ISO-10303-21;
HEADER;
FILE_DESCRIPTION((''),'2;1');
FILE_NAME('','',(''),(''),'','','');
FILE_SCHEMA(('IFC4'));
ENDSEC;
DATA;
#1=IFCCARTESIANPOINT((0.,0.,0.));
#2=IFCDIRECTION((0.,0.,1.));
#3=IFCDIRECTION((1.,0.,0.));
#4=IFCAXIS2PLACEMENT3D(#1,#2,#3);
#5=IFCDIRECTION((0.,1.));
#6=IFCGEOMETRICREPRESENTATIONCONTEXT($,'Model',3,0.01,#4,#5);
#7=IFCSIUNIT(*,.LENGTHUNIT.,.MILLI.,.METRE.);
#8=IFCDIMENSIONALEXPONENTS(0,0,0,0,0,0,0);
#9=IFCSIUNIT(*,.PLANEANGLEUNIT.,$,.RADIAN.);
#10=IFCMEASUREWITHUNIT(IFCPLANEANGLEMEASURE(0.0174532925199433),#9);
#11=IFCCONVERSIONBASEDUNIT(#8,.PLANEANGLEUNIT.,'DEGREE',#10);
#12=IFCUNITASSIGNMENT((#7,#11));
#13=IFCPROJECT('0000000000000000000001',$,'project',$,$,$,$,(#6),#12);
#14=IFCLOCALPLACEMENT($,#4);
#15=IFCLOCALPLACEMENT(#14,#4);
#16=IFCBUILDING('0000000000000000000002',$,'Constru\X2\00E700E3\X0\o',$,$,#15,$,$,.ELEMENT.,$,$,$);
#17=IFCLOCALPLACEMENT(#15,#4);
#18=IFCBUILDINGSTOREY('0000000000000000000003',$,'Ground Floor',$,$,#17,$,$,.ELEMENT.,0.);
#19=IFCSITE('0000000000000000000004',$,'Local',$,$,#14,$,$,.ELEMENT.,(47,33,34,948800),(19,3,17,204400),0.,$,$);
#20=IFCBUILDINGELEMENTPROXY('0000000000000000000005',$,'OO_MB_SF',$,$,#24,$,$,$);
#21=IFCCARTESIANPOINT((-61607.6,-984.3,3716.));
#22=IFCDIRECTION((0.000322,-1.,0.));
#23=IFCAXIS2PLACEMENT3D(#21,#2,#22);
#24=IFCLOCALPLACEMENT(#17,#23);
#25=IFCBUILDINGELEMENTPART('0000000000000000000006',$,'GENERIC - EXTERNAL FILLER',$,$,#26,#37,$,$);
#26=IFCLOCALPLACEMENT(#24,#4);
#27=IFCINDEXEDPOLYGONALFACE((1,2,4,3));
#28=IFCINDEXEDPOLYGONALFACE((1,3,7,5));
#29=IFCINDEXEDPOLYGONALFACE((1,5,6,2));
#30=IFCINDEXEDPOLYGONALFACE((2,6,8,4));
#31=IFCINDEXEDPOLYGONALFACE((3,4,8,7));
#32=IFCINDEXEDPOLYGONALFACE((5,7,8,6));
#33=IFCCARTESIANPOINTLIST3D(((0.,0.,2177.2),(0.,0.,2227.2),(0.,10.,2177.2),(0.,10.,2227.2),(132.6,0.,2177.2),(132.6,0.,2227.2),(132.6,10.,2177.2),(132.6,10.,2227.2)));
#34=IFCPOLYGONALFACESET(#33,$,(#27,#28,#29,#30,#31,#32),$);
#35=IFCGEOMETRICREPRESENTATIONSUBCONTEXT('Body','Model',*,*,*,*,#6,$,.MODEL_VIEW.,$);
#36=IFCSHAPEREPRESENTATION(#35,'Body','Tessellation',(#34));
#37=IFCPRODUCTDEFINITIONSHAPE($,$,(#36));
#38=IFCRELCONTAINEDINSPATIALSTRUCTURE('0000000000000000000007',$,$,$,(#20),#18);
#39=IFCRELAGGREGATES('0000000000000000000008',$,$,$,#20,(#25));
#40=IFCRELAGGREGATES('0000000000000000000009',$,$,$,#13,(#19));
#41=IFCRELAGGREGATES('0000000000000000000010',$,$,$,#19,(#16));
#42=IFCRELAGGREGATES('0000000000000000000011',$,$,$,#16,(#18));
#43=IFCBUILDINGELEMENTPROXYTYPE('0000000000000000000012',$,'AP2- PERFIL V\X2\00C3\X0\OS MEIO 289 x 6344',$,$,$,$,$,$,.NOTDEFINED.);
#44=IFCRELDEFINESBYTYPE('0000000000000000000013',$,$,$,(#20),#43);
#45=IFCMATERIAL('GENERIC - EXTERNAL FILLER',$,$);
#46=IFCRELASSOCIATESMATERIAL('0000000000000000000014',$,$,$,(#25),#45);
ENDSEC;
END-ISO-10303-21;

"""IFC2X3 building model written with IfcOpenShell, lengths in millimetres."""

from ifc_helpers import new_model, entity, si_unit, converted_unit, direction, frame, origin_with_axes, place, context, subcontext, project, spatial, polyline, outline, extrude, material, type_object, element, aggregate, save


model = new_model("IFC2X3")

# Units and contexts
model_context = context("Model", 3, precision=0.01, world=origin_with_axes(), true_north=direction((0.0, 1.0)))
body_context = subcontext(model_context, "Body", "Model", "MODEL_VIEW")
ifc_project = project(units=[si_unit("LENGTHUNIT", "METRE", prefix="MILLI"), converted_unit("PLANEANGLEUNIT", "DEGREE", entity("IfcPlaneAngleMeasure", 0.0174532925199433), si_unit("PLANEANGLEUNIT", "RADIAN"), dimensions=[0, 0, 0, 0, 0, 0, 0])], contexts=[model_context])

# Site, building, storey
site_placement = place(None, origin_with_axes())
site = spatial("IfcSite", under=ifc_project, at=site_placement, Name="Local", CompositionType="ELEMENT", RefLatitude=(47, 33, 34, 948800), RefLongitude=(19, 3, 17, 204400), RefElevation=0.0)
building_placement = place(site_placement, origin_with_axes())
building = spatial("IfcBuilding", under=site, at=building_placement, Name="Construção", CompositionType="ELEMENT")
storey_placement = place(building_placement, origin_with_axes())
storey = spatial("IfcBuildingStorey", under=building, at=storey_placement, Name="Ground Floor", CompositionType="ELEMENT", Elevation=0.0)

# Building element proxy, building element part
building_element_proxy_type = type_object("IfcBuildingElementProxyType", Name="AP2- PERFIL VÃOS MEIO 289 x 6344", PredefinedType="NOTDEFINED")
ifc_material_1 = material(Name="GENERIC - EXTERNAL FILLER")
proxy_1_placement = place(storey_placement, frame((-61607.6, -984.3, 3716.0), z_axis=(0.0, 0.0, 1.0), x_axis=(0.000322, -1.0, 0.0)))
proxy_1 = element("IfcBuildingElementProxy", 1, at=proxy_1_placement, inside=storey, type_object=building_element_proxy_type, Name="OO_MB_SF")
building_element_part_1_placement = place(proxy_1_placement, origin_with_axes())
building_element_part_1 = element("IfcBuildingElementPart", 2, at=building_element_part_1_placement, material=ifc_material_1, Name="GENERIC - EXTERNAL FILLER", context=body_context, shape_type="SweptSolid", body=[
    extrude(outline(polyline([(0.0, 2227.2), (0.0, 2177.2), (132.6, 2177.2), (132.6, 2227.2), (0.0, 2227.2)])), frame((0.0, 10.0, 0.0), z_axis=(0.0, -1.0, 0.0), x_axis=(1.0, 0.0, 0.0)), (0.0, 0.0, 1.0), 10.0),
])
aggregate(proxy_1, [building_element_part_1])

save(model, "model.ifc")
